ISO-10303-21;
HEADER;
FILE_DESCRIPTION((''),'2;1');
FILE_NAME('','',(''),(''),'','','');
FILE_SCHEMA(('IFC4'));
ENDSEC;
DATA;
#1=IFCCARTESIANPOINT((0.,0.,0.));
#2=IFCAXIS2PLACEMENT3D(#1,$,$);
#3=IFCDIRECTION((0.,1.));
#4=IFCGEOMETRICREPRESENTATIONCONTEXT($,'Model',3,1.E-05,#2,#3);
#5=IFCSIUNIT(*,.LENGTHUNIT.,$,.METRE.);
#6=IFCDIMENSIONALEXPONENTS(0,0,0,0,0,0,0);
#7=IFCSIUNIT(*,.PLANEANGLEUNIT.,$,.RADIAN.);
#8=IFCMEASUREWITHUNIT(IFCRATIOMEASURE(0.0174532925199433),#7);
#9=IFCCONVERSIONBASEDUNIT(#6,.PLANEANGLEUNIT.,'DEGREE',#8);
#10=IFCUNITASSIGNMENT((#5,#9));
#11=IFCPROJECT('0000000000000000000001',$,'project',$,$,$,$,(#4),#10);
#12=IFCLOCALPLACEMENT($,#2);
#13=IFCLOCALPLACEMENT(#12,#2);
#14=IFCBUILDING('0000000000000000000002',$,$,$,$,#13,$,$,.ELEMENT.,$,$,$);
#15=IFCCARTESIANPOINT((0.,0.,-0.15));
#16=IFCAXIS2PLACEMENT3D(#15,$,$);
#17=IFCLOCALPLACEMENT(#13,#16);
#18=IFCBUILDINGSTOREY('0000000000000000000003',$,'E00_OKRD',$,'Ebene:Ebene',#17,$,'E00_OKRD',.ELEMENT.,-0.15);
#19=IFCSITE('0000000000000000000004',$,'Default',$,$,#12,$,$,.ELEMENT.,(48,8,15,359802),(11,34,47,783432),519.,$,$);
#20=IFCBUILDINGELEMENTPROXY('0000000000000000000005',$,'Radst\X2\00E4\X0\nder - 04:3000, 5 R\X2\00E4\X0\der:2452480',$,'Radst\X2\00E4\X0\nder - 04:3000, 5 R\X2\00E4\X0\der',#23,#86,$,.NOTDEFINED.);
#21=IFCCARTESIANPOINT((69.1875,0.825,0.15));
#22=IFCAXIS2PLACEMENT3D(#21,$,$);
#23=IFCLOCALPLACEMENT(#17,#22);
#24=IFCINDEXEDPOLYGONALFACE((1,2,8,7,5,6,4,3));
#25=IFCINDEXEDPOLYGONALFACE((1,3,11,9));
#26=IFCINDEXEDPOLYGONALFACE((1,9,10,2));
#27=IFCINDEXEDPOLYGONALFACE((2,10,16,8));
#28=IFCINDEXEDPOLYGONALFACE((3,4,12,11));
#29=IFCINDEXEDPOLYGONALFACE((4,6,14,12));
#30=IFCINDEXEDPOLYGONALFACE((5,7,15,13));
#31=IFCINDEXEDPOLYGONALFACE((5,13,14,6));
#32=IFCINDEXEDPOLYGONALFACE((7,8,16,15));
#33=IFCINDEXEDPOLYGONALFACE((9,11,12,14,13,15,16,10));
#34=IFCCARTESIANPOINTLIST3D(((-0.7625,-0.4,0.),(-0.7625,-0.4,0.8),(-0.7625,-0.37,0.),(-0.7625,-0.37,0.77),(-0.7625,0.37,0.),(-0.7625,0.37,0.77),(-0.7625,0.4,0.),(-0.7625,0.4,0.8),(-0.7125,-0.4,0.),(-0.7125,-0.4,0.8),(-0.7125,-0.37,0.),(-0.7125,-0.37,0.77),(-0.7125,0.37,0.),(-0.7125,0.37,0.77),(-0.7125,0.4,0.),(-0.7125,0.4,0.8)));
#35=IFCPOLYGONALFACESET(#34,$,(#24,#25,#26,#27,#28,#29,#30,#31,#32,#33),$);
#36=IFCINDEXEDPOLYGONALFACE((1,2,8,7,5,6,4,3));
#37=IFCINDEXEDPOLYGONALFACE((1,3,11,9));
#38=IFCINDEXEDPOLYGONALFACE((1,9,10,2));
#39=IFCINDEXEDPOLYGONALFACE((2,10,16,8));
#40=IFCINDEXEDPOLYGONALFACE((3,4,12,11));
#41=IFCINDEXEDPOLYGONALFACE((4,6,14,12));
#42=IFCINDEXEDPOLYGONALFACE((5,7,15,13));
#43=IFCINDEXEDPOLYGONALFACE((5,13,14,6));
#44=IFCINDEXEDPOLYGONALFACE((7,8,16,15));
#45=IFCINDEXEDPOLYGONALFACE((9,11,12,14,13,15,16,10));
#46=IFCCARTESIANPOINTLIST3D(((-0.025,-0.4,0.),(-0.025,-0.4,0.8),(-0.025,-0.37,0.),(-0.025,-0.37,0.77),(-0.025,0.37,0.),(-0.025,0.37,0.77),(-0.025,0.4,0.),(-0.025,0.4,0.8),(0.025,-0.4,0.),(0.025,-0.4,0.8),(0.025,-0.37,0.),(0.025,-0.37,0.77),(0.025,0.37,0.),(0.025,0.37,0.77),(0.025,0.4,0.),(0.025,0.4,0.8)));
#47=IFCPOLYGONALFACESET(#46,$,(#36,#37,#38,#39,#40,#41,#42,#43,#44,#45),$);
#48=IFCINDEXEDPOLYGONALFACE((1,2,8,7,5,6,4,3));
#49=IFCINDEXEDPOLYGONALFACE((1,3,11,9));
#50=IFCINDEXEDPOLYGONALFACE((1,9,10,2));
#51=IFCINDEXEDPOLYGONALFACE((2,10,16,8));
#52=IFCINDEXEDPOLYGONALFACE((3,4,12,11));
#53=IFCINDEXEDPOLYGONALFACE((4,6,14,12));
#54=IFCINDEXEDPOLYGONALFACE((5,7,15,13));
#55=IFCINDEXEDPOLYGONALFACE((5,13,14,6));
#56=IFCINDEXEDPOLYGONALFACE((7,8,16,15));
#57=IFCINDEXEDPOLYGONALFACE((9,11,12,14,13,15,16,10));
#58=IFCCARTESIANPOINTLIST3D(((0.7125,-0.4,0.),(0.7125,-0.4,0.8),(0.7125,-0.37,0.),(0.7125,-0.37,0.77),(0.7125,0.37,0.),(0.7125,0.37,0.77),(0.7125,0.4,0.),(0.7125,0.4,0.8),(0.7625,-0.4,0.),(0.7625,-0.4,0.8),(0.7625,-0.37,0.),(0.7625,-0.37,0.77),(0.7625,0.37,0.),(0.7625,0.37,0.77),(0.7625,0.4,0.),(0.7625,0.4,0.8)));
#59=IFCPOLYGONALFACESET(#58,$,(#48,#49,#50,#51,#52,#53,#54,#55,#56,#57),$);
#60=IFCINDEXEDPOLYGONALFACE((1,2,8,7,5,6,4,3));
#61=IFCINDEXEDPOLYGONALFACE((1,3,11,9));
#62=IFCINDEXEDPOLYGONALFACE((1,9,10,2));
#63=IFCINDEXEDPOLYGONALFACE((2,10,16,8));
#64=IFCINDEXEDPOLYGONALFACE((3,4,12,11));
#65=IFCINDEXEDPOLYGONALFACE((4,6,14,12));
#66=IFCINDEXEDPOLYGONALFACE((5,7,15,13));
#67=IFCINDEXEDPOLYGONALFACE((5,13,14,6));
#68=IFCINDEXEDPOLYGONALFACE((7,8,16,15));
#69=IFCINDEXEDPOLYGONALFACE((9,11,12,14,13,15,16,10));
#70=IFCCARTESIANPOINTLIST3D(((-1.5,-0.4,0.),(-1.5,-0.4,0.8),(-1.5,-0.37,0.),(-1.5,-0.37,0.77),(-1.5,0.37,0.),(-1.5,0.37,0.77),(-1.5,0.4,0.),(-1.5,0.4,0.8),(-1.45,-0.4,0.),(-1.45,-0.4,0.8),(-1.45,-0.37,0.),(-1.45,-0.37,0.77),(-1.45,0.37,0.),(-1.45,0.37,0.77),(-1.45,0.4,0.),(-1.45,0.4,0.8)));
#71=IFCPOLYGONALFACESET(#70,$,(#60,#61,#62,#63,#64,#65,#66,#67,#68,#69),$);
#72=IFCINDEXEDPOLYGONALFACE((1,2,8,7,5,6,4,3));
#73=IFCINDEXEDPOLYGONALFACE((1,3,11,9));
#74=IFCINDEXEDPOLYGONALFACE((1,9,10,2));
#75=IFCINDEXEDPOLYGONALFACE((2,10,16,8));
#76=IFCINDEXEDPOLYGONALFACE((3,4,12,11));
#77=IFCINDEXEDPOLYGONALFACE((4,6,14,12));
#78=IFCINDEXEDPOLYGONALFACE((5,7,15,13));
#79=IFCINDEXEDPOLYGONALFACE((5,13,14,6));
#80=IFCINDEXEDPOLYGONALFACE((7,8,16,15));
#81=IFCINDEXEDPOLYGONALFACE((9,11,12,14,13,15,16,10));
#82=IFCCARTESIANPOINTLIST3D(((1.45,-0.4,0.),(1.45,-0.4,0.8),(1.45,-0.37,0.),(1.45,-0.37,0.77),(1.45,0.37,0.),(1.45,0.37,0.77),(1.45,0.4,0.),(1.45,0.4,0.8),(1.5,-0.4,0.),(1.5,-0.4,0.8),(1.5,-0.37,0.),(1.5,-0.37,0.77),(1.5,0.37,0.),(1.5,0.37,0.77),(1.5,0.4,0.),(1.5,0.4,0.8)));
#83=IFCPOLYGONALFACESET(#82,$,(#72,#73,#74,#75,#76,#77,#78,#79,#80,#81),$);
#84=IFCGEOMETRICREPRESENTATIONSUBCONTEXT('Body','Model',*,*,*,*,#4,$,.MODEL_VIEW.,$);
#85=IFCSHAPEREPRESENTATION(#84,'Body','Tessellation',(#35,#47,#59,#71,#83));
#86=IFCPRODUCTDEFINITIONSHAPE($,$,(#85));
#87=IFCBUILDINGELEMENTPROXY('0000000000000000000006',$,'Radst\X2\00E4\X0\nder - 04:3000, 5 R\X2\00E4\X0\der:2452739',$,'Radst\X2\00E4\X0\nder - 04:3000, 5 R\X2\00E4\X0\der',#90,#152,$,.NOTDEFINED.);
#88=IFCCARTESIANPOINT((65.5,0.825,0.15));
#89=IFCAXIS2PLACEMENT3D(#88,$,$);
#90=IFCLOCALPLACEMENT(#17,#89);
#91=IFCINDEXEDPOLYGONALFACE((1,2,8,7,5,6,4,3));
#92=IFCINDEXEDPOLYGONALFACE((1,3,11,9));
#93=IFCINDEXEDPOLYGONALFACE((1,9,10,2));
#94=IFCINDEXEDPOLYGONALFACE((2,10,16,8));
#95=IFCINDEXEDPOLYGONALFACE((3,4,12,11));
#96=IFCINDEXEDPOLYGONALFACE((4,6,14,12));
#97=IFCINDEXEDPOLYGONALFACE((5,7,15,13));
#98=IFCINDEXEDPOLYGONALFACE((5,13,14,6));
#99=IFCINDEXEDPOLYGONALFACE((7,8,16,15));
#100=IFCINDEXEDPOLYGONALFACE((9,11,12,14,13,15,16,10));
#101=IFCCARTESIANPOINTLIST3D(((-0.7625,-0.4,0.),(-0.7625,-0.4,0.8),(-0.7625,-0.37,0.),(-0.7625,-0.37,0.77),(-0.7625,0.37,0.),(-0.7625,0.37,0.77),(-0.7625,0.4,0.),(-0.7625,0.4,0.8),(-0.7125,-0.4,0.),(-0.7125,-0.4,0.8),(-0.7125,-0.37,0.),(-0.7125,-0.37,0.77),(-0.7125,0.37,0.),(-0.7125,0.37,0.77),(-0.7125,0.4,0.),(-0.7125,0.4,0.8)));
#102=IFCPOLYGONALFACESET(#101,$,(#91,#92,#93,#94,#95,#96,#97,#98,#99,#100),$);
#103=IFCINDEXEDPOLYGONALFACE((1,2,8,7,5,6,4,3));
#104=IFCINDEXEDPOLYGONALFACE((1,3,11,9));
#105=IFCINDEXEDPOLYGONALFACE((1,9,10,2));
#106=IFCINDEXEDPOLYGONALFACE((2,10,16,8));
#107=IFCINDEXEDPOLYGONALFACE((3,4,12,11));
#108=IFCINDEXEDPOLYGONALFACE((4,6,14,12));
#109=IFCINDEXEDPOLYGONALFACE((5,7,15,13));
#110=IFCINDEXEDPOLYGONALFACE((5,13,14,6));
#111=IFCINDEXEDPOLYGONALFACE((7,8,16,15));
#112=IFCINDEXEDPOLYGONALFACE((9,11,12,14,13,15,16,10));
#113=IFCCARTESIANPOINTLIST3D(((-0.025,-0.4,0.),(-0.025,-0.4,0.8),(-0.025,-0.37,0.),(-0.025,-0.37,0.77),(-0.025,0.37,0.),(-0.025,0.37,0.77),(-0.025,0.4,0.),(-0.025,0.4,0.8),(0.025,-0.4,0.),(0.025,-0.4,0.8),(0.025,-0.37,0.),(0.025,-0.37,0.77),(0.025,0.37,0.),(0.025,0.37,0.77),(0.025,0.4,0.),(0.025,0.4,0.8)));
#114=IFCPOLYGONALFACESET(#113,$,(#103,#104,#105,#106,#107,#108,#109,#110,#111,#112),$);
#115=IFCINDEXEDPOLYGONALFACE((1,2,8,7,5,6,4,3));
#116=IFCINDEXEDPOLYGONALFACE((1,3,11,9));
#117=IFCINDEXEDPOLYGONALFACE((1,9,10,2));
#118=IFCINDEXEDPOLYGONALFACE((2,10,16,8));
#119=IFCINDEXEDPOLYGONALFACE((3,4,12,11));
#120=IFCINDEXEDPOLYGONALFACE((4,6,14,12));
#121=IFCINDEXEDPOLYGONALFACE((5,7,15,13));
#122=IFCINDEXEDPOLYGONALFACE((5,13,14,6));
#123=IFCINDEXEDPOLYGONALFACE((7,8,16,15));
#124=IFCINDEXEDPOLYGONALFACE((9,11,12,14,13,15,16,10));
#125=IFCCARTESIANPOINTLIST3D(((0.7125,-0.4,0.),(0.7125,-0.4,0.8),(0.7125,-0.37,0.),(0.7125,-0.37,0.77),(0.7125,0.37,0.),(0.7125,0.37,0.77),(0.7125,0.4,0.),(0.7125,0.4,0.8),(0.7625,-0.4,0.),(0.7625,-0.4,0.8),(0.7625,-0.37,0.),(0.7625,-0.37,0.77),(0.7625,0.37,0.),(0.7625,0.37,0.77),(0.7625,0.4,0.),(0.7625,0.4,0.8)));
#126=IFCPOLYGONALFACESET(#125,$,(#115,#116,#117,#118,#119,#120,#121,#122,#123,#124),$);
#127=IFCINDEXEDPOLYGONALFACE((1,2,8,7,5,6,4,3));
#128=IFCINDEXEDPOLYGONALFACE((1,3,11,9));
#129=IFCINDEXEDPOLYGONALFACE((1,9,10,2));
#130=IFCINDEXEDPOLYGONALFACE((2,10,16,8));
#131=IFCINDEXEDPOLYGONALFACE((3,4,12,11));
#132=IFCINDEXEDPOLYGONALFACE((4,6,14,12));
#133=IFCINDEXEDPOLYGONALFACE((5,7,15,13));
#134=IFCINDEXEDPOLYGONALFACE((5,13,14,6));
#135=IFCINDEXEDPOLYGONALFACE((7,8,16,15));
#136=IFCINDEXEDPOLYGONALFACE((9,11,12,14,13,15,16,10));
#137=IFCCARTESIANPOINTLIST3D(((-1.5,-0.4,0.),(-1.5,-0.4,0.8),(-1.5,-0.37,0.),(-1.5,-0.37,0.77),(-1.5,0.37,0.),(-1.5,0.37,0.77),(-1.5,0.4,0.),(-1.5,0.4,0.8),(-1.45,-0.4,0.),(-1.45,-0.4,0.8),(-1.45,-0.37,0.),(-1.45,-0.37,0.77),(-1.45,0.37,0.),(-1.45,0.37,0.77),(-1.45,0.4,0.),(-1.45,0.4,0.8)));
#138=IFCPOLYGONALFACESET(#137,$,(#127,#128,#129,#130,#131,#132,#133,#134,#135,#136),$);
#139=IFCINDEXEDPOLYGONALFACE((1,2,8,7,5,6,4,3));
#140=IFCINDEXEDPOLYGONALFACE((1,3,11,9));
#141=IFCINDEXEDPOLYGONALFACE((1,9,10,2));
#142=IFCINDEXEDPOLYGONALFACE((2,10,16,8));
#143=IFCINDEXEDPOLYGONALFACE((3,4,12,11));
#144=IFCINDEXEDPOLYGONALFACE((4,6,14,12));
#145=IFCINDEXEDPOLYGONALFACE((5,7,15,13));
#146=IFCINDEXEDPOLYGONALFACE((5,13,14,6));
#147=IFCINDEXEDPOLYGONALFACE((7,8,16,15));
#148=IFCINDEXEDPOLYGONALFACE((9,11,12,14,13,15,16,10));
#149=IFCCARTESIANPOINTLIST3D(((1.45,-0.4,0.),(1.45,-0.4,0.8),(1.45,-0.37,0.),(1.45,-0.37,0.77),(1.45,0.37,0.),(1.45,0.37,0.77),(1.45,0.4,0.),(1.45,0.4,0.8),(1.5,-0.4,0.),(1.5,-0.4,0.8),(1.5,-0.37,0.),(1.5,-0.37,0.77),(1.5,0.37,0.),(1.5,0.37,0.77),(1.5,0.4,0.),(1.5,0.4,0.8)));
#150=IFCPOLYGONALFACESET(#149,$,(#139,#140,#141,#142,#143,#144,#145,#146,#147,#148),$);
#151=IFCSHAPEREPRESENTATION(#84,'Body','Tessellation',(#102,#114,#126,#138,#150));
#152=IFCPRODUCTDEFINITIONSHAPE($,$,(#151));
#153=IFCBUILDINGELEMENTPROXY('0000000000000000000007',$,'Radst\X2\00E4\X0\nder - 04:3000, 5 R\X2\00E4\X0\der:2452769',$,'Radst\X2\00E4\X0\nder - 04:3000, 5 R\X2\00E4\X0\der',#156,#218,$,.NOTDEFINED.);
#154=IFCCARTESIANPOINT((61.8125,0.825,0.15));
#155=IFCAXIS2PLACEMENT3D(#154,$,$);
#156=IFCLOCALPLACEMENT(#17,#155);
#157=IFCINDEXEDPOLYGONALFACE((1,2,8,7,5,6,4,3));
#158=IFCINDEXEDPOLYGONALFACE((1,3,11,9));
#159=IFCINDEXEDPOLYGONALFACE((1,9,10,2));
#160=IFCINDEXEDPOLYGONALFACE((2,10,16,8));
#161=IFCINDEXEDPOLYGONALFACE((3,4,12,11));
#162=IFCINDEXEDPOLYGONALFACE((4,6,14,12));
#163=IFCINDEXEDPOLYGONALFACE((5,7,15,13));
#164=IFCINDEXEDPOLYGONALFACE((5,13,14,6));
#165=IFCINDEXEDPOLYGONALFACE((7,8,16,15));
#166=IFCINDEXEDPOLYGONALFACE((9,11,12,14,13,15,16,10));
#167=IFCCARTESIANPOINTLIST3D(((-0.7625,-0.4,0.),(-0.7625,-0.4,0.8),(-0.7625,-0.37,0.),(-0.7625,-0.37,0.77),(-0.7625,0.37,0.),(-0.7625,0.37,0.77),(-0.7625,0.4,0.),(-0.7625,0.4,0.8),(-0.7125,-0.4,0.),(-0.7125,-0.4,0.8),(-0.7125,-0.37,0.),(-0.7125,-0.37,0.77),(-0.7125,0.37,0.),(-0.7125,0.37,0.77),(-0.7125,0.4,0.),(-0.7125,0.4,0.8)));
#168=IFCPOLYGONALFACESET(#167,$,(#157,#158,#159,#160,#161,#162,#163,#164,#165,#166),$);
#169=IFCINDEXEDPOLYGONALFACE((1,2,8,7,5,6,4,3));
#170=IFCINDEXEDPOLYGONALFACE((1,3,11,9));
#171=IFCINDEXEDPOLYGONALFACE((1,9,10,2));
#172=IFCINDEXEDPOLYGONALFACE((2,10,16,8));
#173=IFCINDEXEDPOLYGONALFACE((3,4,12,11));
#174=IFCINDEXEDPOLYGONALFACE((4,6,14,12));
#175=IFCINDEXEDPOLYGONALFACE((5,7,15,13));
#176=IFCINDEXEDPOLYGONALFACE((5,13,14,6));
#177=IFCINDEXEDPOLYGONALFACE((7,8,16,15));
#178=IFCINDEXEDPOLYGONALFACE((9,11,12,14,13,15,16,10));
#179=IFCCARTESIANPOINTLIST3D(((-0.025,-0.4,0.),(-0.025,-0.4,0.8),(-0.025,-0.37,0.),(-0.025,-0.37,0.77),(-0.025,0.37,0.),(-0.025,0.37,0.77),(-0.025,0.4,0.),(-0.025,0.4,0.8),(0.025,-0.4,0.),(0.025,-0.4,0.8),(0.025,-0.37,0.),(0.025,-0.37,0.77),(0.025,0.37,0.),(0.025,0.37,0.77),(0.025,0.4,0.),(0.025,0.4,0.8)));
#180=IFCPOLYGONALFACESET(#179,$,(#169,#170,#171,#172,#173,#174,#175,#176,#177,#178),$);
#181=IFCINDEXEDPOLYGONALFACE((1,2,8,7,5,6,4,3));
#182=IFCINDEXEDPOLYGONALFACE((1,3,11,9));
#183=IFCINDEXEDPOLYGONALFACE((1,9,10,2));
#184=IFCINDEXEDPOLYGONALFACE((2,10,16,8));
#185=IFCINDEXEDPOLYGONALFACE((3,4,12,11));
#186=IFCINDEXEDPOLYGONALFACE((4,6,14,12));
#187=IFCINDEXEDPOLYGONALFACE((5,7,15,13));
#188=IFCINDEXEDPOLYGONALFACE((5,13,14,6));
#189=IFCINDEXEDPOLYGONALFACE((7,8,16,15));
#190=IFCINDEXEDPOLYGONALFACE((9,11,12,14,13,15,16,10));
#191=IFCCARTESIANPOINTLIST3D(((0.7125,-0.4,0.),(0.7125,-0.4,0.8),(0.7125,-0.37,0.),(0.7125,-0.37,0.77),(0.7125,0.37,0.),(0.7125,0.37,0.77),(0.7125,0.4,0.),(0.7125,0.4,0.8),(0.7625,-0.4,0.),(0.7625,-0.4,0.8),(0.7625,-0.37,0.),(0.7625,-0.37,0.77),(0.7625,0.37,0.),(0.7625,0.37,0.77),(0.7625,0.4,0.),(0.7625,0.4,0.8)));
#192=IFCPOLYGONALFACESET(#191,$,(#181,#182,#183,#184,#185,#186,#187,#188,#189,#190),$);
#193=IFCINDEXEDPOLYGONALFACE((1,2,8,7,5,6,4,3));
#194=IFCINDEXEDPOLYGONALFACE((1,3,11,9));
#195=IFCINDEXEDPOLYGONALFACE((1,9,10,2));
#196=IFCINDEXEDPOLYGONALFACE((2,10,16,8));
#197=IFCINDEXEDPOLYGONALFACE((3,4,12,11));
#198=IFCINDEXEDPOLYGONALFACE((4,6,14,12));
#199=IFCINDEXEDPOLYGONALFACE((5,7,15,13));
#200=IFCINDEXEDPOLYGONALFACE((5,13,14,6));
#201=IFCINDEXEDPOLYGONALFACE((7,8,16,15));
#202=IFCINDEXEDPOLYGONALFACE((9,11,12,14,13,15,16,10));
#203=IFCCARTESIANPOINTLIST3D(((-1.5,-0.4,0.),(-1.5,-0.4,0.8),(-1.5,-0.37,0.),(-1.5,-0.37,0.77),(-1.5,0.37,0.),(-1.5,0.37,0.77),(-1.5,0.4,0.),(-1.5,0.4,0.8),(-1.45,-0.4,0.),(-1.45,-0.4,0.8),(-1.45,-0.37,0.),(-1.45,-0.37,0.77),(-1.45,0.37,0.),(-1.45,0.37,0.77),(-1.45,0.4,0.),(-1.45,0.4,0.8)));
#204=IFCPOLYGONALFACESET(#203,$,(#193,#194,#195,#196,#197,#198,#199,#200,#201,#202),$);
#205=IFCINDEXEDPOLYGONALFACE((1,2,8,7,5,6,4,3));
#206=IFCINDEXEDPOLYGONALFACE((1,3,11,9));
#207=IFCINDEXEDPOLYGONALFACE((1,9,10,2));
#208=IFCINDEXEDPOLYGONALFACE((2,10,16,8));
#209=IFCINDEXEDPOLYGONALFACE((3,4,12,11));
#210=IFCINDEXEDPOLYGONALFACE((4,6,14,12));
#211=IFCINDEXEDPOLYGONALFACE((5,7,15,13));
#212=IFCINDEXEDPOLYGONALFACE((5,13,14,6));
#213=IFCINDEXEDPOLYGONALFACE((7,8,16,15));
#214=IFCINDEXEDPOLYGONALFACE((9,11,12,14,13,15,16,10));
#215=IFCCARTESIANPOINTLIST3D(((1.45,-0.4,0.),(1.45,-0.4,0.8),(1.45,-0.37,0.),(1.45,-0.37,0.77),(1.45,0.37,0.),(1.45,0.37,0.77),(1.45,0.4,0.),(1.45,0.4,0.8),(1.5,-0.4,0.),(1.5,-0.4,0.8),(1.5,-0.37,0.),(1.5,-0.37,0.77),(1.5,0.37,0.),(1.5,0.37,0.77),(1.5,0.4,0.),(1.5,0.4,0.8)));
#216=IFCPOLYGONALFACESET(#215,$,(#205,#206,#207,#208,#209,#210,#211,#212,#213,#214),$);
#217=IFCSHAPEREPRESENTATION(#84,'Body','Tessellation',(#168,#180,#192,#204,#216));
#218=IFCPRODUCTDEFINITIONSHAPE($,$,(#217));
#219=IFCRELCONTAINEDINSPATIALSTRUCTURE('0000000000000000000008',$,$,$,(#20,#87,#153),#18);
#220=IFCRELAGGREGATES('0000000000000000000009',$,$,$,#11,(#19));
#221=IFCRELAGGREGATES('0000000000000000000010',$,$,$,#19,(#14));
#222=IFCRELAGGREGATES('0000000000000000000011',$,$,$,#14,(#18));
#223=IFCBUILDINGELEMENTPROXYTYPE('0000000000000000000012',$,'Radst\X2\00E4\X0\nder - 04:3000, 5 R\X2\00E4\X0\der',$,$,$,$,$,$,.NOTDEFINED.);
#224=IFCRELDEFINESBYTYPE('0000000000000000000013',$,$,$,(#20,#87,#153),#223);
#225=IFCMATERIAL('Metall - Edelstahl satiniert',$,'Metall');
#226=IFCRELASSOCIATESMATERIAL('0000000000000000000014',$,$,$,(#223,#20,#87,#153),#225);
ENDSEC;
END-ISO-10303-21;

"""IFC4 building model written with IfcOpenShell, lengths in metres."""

from ifc_helpers import new_model, entity, si_unit, converted_unit, direction, frame, origin, place, context, subcontext, project, spatial, polyline, outline, extrude, source, transform, mapped, material, type_object, type_shapes, element, save


model = new_model("IFC4")

# Units and contexts
model_context = context("Model", 3, precision=1e-05, world=origin(), true_north=direction((0.0, 1.0)))
body_context = subcontext(model_context, "Body", "Model", "MODEL_VIEW")
ifc_project = project(units=[si_unit("LENGTHUNIT", "METRE"), converted_unit("PLANEANGLEUNIT", "DEGREE", entity("IfcRatioMeasure", 0.0174532925199433), si_unit("PLANEANGLEUNIT", "RADIAN"), dimensions=[0, 0, 0, 0, 0, 0, 0])], contexts=[model_context])

# Site, building, storey
site_placement = place(None, frame((0.0, 0.0, 0.0)))
site = spatial("IfcSite", under=ifc_project, at=site_placement, Name="Default", CompositionType="ELEMENT", RefLatitude=(48, 8, 15, 359802), RefLongitude=(11, 34, 47, 783432), RefElevation=519.0)
building_placement = place(site_placement, origin())
building = spatial("IfcBuilding", under=site, at=building_placement, CompositionType="ELEMENT")
storey_placement = place(building_placement, frame((0.0, 0.0, -0.15)))
storey = spatial("IfcBuildingStorey", under=building, at=storey_placement, Name="E00_OKRD", ObjectType="Ebene:Ebene", LongName="E00_OKRD", CompositionType="ELEMENT", Elevation=-0.15)

# Building element proxies
ifc_material_1 = material(Name="Metall - Edelstahl satiniert", Category="Metall")
building_element_proxy_type_1 = type_object("IfcBuildingElementProxyType", Name="Radständer - 04:3000, 5 Räder", PredefinedType="NOTDEFINED", material=ifc_material_1)
shared_shape_1 = source(origin(), body_context, "Body", "SweptSolid", [
    extrude(outline(polyline([(-0.4075, -0.4), (0.3925, -0.4), (0.3925, -0.37), (-0.3775, -0.37), (-0.3775, 0.37), (0.3925, 0.37), (0.3925, 0.4), (-0.4075, 0.4), (-0.4075, -0.4)])), frame((-0.7625, 0.0, 0.3925), z_axis=(1.0, 0.0, 0.0), x_axis=(0.0, 0.0, -1.0)), (0.0, 0.0, 1.0), 0.05),
    extrude(outline(polyline([(-0.4075, -0.4), (0.3925, -0.4), (0.3925, -0.37), (-0.3775, -0.37), (-0.3775, 0.37), (0.3925, 0.37), (0.3925, 0.4), (-0.4075, 0.4), (-0.4075, -0.4)])), frame((-0.025, 0.0, 0.3925), z_axis=(1.0, 0.0, 0.0), x_axis=(0.0, 0.0, -1.0)), (0.0, 0.0, 1.0), 0.05),
    extrude(outline(polyline([(-0.4075, -0.4), (0.3925, -0.4), (0.3925, -0.37), (-0.3775, -0.37), (-0.3775, 0.37), (0.3925, 0.37), (0.3925, 0.4), (-0.4075, 0.4), (-0.4075, -0.4)])), frame((0.7125, 0.0, 0.3925), z_axis=(1.0, 0.0, 0.0), x_axis=(0.0, 0.0, -1.0)), (0.0, 0.0, 1.0), 0.05),
    extrude(outline(polyline([(-0.4075, -0.4), (0.3925, -0.4), (0.3925, -0.37), (-0.3775, -0.37), (-0.3775, 0.37), (0.3925, 0.37), (0.3925, 0.4), (-0.4075, 0.4), (-0.4075, -0.4)])), frame((-1.5, 0.0, 0.3925), z_axis=(1.0, 0.0, 0.0), x_axis=(0.0, 0.0, -1.0)), (0.0, 0.0, 1.0), 0.05),
    extrude(outline(polyline([(-0.4075, -0.4), (0.3925, -0.4), (0.3925, -0.37), (-0.3775, -0.37), (-0.3775, 0.37), (0.3925, 0.37), (0.3925, 0.4), (-0.4075, 0.4), (-0.4075, -0.4)])), frame((1.45, 0.0, 0.3925), z_axis=(1.0, 0.0, 0.0), x_axis=(0.0, 0.0, -1.0)), (0.0, 0.0, 1.0), 0.05),
])
type_shapes(building_element_proxy_type_1, [shared_shape_1])
for number, where, name in (
    (1, (69.1875, 0.825, 0.15), "Radständer - 04:3000, 5 Räder:2452480"),
    (2, (65.5, 0.825, 0.15), "Radständer - 04:3000, 5 Räder:2452739"),
    (3, (61.8125, 0.825, 0.15), "Radständer - 04:3000, 5 Räder:2452769"),
):
    element("IfcBuildingElementProxy", number, at=place(storey_placement, frame(where)), inside=storey, type_object=building_element_proxy_type_1, material=ifc_material_1, Name=name, ObjectType="Radständer - 04:3000, 5 Räder", PredefinedType="NOTDEFINED", context=body_context, shape_type="MappedRepresentation", body=[
        mapped(shared_shape_1, transform((0.0, 0.0, 0.0), scale=1.0)),
    ])

save(model, "model.ifc")
